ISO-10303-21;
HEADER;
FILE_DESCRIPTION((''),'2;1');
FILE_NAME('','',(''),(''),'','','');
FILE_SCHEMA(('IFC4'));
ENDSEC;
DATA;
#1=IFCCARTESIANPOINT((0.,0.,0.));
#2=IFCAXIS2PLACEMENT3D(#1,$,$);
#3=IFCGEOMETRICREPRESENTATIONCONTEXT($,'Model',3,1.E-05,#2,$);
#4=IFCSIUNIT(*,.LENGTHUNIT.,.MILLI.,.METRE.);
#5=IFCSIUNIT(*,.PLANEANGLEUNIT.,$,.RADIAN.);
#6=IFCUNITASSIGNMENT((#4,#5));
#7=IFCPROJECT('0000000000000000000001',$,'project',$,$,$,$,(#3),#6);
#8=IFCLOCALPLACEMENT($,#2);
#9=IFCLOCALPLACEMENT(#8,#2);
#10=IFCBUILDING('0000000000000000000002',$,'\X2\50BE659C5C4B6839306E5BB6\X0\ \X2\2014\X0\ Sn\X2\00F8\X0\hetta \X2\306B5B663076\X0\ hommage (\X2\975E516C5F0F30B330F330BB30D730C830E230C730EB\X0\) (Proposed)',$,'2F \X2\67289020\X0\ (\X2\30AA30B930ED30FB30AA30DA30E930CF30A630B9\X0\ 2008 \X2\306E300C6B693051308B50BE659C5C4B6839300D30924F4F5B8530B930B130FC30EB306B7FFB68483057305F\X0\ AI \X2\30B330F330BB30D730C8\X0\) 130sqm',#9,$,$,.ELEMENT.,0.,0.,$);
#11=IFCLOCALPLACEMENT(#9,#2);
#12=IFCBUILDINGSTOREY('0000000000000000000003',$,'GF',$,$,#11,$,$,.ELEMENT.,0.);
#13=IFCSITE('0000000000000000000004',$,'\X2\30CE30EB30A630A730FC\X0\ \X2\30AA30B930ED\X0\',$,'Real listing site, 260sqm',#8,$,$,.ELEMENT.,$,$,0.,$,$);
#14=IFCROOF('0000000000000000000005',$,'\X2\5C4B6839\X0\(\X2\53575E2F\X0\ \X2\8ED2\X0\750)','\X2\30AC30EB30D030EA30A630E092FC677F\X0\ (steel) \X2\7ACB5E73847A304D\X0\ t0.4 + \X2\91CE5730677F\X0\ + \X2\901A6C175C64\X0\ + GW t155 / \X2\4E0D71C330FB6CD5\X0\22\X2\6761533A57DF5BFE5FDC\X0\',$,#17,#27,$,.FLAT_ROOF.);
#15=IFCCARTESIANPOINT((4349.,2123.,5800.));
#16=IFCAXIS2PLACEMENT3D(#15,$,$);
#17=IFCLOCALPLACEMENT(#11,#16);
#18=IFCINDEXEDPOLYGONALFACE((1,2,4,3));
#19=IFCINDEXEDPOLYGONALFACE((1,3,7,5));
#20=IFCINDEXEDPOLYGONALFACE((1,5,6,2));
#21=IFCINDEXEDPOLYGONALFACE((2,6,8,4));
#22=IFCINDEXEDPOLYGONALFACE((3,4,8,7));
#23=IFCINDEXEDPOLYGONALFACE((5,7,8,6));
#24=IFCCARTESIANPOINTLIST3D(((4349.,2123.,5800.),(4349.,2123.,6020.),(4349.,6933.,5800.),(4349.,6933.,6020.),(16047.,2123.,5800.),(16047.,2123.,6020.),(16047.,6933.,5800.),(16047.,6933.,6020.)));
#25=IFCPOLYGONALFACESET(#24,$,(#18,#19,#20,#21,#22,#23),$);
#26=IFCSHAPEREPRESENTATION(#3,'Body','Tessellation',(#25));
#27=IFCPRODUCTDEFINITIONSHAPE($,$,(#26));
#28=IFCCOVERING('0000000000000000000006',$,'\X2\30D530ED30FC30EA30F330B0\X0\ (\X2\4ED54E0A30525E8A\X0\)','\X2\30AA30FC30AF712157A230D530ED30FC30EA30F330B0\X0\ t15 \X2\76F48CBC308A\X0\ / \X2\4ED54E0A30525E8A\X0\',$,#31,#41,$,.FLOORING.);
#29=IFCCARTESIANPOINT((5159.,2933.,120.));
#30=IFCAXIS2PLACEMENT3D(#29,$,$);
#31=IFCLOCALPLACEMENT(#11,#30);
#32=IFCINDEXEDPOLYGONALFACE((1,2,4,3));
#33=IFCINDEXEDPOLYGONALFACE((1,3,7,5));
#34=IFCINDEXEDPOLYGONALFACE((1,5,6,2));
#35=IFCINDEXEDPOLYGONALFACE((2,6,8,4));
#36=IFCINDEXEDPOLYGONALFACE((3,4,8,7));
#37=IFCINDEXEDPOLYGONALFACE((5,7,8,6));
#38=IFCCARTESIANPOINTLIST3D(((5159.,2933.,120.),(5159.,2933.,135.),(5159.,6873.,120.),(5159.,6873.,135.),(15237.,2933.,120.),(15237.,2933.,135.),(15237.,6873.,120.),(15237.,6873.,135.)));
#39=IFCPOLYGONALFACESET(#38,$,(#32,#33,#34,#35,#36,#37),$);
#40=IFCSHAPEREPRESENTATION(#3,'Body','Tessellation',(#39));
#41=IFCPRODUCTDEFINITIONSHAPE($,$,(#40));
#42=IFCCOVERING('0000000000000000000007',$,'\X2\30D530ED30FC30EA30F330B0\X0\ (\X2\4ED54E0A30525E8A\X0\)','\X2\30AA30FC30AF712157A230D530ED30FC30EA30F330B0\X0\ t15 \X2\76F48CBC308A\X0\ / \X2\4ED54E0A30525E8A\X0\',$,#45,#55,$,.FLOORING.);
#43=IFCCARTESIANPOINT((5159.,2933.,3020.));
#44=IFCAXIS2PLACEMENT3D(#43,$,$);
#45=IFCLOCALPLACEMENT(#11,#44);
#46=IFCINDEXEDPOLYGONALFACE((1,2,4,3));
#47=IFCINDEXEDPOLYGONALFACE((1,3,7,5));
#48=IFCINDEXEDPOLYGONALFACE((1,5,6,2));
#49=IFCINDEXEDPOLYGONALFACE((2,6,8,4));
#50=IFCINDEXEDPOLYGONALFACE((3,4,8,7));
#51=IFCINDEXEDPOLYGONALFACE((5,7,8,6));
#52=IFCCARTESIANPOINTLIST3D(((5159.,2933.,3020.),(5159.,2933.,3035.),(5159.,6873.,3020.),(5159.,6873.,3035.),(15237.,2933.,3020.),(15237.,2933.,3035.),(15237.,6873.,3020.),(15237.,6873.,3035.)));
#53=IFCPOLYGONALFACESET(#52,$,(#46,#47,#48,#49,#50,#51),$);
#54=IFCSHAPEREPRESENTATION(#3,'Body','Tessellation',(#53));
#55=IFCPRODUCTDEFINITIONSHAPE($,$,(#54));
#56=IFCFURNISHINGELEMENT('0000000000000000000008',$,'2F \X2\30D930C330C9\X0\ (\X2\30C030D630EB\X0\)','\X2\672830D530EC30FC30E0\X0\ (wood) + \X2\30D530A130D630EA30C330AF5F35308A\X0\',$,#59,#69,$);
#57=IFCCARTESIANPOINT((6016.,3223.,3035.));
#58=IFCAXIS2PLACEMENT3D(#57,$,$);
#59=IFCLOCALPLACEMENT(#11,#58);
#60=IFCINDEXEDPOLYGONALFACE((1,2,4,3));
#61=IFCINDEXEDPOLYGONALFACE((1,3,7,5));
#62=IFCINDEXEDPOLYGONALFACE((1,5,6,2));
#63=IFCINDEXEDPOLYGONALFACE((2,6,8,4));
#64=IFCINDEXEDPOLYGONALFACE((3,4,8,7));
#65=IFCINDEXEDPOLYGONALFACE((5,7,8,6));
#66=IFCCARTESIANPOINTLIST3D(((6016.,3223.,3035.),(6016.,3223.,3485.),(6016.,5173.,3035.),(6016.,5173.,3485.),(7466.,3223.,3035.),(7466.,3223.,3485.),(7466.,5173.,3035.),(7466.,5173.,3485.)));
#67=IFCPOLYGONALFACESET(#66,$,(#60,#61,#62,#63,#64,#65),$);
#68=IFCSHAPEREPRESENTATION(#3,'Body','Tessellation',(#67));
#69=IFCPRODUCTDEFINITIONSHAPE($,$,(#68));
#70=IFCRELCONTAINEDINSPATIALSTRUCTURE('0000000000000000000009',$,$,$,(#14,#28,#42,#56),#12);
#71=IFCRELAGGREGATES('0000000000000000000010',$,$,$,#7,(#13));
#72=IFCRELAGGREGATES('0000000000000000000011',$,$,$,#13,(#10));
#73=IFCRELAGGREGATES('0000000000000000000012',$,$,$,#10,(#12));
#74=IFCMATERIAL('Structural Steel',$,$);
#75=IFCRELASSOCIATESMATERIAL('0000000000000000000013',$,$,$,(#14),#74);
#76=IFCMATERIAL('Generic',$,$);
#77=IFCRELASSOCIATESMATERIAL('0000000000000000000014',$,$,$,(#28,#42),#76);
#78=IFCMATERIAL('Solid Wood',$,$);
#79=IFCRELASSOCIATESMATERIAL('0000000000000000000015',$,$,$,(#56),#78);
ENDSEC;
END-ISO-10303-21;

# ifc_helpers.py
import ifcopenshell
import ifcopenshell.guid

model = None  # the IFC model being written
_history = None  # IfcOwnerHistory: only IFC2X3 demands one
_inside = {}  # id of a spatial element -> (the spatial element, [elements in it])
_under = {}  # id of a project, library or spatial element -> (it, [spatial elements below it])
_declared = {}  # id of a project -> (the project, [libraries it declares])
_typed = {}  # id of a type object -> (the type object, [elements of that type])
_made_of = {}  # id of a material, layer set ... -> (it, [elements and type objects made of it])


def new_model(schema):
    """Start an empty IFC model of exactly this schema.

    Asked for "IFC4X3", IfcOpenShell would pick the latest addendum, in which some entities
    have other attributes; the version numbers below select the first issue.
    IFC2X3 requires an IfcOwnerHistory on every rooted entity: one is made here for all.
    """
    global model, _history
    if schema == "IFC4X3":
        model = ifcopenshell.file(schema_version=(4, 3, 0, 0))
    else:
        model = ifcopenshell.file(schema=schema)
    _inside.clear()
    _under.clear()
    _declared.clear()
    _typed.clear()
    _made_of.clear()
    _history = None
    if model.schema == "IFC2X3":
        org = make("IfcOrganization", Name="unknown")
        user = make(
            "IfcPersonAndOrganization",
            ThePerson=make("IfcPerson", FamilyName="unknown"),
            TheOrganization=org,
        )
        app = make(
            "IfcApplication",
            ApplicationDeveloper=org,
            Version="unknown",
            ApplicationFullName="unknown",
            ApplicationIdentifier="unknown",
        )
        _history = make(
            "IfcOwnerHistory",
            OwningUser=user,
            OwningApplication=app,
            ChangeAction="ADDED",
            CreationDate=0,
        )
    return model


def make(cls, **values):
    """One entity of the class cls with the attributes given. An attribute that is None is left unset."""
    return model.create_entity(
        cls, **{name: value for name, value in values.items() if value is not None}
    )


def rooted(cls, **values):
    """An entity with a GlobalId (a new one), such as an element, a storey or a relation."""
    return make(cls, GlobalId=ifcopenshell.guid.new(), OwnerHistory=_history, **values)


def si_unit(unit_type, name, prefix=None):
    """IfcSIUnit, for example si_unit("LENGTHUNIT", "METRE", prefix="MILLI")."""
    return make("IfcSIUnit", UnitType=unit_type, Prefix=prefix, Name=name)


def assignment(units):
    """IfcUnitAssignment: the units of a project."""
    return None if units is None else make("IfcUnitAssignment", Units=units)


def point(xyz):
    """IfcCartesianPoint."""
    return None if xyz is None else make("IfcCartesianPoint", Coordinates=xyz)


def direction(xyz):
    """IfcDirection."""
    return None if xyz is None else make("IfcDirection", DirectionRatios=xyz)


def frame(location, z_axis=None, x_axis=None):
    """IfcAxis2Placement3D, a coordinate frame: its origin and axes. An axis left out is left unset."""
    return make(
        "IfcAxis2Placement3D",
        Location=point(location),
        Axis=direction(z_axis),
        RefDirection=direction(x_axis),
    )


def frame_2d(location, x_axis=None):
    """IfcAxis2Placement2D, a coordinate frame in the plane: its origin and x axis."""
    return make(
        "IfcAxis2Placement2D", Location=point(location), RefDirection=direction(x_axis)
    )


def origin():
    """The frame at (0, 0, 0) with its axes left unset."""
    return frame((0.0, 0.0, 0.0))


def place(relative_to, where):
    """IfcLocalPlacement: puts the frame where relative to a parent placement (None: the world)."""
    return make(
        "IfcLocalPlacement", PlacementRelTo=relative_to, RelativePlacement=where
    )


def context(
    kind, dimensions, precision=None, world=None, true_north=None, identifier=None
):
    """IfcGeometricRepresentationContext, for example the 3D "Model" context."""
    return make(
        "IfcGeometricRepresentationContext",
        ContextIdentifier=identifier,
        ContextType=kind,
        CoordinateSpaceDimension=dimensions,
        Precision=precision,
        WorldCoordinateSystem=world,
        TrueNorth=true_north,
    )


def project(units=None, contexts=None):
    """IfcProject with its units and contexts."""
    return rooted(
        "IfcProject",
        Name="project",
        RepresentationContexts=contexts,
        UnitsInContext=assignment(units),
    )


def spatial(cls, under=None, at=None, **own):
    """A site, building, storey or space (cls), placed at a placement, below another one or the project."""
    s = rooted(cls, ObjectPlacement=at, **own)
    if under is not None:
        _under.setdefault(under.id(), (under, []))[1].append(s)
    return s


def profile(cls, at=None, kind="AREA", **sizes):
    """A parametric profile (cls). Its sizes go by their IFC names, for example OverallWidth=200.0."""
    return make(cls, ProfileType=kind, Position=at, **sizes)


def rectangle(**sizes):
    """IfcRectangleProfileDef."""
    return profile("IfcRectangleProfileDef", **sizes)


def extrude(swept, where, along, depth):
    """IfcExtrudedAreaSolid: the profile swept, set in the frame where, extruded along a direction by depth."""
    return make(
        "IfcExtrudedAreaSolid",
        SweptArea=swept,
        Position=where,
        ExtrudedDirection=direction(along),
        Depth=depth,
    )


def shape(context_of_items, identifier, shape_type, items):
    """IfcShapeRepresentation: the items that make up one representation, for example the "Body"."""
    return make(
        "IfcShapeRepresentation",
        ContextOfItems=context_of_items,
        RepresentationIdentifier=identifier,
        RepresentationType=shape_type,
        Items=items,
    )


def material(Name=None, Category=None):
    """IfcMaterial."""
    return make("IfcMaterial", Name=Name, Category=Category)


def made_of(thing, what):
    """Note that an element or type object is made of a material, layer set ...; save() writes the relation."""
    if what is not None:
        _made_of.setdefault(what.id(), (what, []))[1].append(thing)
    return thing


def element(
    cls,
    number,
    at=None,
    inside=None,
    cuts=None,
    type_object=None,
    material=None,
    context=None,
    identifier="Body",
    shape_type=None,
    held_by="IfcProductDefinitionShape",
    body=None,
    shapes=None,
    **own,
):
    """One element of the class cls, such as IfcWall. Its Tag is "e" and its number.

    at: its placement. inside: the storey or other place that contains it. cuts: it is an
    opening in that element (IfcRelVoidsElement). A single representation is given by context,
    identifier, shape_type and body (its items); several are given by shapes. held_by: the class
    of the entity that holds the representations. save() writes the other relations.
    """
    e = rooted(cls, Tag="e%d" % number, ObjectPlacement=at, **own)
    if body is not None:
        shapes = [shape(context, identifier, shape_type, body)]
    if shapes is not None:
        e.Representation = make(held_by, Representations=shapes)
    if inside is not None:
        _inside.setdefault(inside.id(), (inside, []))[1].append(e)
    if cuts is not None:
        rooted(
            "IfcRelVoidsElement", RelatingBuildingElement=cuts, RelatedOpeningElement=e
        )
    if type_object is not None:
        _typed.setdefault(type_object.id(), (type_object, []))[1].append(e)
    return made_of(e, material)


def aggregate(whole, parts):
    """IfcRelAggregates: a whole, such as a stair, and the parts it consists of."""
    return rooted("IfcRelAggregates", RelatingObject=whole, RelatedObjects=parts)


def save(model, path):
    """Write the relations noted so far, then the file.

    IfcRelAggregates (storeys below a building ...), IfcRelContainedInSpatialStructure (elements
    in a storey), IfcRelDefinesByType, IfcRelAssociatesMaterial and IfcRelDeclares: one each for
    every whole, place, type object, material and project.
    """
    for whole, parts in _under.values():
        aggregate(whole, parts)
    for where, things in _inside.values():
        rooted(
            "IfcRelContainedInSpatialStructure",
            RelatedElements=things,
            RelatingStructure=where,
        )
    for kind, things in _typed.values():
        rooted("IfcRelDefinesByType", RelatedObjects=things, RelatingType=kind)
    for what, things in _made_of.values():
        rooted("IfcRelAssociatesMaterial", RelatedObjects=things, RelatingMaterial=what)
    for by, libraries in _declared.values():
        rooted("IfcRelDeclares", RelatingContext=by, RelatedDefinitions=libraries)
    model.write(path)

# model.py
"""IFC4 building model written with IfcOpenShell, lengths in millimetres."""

from ifc_helpers import new_model, si_unit, frame, frame_2d, origin, place, context, project, spatial, rectangle, extrude, material, element, save


model = new_model("IFC4")

# Units and contexts
model_context = context("Model", 3, precision=1e-05, world=origin())
ifc_project = project(units=[si_unit("LENGTHUNIT", "METRE", prefix="MILLI"), si_unit("PLANEANGLEUNIT", "RADIAN")], contexts=[model_context])

# Site, building, storey
site_placement = place(None, origin())
site = spatial("IfcSite", under=ifc_project, at=site_placement, Name="ノルウェー オスロ", ObjectType="Real listing site, 260sqm", CompositionType="ELEMENT", RefElevation=0.0)
building_placement = place(site_placement, origin())
building = spatial("IfcBuilding", under=site, at=building_placement, Name="傾斜屋根の家 — Snøhetta に学ぶ hommage (非公式コンセプトモデル) (Proposed)", ObjectType="2F 木造 (オスロ・オペラハウス 2008 の「歩ける傾斜屋根」を住宅スケールに翻案した AI コンセプト) 130sqm", CompositionType="ELEMENT", ElevationOfRefHeight=0.0, ElevationOfTerrain=0.0)
storey_placement = place(building_placement, origin())
storey = spatial("IfcBuildingStorey", under=building, at=storey_placement, Name="GF", CompositionType="ELEMENT", Elevation=0.0)

# Shared definitions
ifc_material_1 = material(Name="Solid Wood")

# Roof
ifc_material_2 = material(Name="Structural Steel")
for number, where, name in (
    (1, (4349.0, 2123.0, 5800.0), "屋根(南帯 軒750)"),
):
    element("IfcRoof", number, at=place(storey_placement, frame(where)), inside=storey, material=ifc_material_2, Name=name, Description="ガルバリウム鋼板 (steel) 立平葺き t0.4 + 野地板 + 通気層 + GW t155 / 不燃・法22条区域対応", PredefinedType="FLAT_ROOF", context=model_context, shape_type="SweptSolid", body=[
        extrude(rectangle(XDim=11698.0, YDim=4810.0, at=frame_2d((5849.0, 2405.0))), frame((4349.0, 2123.0, 5800.0)), (0.0, 0.0, 1.0), 220.0),
    ])

# Coverings
ifc_material_3 = material(Name="Generic")
covering_1_placement = place(storey_placement, frame((5159.0, 2933.0, 120.0)))
element("IfcCovering", 2, at=covering_1_placement, inside=storey, material=ifc_material_3, Name="フローリング (仕上げ床)", Description="オーク無垢フローリング t15 直貼り / 仕上げ床", PredefinedType="FLOORING", context=model_context, shape_type="SweptSolid", body=[
    extrude(rectangle(XDim=10078.0, YDim=3940.0, at=frame_2d((5039.0, 1970.0))), frame((5159.0, 2933.0, 120.0)), (0.0, 0.0, 1.0), 15.0),
])
covering_2_placement = place(storey_placement, frame((5159.0, 2933.0, 3020.0)))
element("IfcCovering", 3, at=covering_2_placement, inside=storey, material=ifc_material_3, Name="フローリング (仕上げ床)", Description="オーク無垢フローリング t15 直貼り / 仕上げ床", PredefinedType="FLOORING", context=model_context, shape_type="SweptSolid", body=[
    extrude(rectangle(XDim=10078.0, YDim=3940.0, at=frame_2d((5039.0, 1970.0))), frame((5159.0, 2933.0, 3020.0)), (0.0, 0.0, 1.0), 15.0),
])

# Furnishing element
furnishing_placement = place(storey_placement, frame((6016.0, 3223.0, 3035.0)))
element("IfcFurnishingElement", 4, at=furnishing_placement, inside=storey, material=ifc_material_1, Name="2F ベッド (ダブル)", Description="木フレーム (wood) + ファブリック張り", context=model_context, shape_type="SweptSolid", body=[
    extrude(rectangle(XDim=1450.0, YDim=1950.0, at=frame_2d((725.0, 975.0))), frame((6016.0, 3223.0, 3035.0)), (0.0, 0.0, 1.0), 450.0),
])

save(model, "model.ifc")
